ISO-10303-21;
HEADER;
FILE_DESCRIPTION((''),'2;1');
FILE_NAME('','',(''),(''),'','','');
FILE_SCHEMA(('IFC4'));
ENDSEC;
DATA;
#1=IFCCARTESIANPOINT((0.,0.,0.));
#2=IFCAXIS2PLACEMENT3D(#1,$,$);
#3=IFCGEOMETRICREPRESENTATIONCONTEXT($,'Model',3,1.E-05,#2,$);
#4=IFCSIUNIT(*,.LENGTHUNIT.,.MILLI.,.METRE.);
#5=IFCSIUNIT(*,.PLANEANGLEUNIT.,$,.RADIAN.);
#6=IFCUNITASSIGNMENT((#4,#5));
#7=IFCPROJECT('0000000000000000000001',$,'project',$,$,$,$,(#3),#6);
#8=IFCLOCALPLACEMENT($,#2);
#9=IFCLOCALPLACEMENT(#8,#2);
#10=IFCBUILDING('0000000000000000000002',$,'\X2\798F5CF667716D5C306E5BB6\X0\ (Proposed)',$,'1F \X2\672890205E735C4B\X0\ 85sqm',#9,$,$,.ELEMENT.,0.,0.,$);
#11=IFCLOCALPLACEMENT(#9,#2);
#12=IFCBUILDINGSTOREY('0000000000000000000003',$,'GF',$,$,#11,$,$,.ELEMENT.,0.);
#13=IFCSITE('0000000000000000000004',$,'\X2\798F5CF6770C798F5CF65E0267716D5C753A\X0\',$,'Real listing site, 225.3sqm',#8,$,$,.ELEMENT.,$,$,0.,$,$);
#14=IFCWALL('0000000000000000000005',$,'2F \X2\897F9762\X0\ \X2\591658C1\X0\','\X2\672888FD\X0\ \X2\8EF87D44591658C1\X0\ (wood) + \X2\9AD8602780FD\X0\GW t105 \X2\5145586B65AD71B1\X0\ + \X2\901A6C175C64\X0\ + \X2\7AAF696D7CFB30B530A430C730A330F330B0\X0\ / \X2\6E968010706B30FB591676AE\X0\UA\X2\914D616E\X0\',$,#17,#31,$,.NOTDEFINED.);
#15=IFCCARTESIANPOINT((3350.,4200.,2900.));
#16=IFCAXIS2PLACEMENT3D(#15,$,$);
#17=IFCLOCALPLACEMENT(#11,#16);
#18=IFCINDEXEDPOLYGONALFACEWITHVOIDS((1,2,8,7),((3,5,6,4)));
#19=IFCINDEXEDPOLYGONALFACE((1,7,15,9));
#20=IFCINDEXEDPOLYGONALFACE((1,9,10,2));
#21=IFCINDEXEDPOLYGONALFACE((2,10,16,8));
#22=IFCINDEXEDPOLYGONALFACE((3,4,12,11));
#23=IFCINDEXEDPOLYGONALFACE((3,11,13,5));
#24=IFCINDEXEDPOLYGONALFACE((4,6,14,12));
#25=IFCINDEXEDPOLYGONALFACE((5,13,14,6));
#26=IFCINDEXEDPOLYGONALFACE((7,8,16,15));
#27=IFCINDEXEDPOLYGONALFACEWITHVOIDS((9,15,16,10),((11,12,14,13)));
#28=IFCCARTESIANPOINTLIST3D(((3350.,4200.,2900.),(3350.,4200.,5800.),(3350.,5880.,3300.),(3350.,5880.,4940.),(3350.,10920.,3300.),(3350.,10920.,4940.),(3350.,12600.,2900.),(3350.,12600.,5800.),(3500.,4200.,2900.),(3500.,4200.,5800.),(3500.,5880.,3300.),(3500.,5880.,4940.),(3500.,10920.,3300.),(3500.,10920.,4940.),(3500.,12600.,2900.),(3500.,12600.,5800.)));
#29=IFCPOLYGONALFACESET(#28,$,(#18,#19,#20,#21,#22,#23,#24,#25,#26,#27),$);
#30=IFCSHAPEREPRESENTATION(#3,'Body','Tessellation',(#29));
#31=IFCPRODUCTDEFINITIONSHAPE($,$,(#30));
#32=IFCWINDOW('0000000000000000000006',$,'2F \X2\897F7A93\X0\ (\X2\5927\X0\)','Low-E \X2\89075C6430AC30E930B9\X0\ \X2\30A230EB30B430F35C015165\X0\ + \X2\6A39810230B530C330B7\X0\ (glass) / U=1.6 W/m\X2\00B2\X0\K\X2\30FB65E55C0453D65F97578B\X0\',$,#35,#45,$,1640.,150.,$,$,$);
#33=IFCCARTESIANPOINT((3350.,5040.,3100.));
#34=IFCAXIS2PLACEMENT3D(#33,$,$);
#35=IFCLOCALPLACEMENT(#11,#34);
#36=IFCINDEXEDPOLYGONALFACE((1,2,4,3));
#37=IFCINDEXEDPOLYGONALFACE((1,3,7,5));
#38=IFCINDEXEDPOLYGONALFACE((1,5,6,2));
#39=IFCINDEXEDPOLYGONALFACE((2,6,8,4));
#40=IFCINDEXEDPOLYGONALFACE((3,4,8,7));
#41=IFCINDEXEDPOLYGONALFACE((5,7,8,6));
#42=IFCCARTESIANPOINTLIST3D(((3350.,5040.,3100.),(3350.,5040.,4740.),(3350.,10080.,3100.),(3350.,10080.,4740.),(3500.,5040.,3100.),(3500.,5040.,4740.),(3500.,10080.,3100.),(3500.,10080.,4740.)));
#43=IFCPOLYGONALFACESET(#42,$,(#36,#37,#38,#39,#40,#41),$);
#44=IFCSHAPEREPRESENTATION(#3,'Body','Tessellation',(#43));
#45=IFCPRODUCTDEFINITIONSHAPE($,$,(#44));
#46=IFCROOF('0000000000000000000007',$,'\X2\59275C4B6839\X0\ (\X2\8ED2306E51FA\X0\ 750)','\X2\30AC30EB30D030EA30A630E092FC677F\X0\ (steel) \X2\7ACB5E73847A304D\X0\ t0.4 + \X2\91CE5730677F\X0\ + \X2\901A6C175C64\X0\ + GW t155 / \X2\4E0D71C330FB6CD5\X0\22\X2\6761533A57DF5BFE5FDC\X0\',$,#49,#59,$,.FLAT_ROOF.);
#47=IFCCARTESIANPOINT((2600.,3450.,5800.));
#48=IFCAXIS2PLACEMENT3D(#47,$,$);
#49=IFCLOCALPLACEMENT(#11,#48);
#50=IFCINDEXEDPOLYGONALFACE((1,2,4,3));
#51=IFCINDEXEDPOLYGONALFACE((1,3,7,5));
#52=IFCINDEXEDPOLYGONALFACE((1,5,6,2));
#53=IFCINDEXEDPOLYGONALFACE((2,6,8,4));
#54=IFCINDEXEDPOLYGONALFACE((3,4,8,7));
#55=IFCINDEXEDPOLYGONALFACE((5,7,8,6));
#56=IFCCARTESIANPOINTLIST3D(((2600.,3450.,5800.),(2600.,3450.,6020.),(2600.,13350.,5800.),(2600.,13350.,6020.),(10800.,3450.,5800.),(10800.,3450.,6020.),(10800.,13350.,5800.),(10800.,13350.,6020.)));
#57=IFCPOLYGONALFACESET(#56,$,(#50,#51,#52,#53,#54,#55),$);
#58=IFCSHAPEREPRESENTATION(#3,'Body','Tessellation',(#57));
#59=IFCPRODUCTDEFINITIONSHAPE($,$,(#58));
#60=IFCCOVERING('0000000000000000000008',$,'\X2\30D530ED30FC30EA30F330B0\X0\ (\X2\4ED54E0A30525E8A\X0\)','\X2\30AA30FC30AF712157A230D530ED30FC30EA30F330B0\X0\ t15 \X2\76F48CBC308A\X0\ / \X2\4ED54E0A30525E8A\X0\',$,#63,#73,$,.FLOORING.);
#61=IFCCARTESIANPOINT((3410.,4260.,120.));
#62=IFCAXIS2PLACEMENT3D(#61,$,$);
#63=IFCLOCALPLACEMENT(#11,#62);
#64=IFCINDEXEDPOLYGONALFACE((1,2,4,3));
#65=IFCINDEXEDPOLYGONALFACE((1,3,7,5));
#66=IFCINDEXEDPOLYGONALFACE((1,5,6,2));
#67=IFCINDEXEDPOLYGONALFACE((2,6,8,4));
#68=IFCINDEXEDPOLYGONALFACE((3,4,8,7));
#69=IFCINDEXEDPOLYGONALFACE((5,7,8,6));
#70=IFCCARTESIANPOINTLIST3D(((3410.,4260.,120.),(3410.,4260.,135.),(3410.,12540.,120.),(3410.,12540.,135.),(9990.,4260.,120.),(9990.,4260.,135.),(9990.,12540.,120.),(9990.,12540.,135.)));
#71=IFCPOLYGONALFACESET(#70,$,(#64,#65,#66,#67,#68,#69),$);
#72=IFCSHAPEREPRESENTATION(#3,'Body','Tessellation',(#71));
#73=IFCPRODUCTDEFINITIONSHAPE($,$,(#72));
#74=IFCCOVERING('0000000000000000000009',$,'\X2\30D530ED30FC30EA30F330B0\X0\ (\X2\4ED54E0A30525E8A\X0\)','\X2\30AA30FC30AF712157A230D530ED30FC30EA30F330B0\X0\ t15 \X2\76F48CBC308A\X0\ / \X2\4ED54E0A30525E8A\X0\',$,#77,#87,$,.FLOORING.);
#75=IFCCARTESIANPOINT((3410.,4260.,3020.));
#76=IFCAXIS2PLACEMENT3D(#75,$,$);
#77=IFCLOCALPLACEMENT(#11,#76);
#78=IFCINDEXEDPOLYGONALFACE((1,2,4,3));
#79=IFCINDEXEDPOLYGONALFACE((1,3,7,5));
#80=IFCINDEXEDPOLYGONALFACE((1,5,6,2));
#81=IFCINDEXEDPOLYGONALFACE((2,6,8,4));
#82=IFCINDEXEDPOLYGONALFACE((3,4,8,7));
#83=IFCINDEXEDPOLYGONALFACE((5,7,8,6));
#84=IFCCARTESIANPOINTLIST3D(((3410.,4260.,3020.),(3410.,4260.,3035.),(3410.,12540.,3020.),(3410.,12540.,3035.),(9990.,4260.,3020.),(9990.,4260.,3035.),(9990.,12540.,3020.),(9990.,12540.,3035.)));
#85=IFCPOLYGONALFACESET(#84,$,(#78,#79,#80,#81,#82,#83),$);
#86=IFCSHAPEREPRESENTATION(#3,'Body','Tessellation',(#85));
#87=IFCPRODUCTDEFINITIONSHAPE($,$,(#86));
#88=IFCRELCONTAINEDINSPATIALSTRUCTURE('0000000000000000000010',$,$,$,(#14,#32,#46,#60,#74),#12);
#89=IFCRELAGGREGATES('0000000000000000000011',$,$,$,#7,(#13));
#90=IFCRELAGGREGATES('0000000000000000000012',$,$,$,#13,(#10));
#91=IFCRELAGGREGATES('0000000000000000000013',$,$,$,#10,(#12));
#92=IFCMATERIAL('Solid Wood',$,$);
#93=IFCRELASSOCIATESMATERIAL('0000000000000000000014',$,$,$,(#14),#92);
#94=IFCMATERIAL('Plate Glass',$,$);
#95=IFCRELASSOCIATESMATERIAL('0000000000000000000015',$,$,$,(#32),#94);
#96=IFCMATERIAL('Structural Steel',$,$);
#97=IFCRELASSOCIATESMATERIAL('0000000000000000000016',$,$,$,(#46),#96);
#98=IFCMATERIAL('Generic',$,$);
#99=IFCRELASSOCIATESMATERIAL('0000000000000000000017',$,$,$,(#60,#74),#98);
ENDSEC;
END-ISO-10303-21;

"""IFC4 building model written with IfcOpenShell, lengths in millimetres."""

from ifc_helpers import new_model, si_unit, frame, frame_2d, origin, place, context, project, spatial, rectangle, extrude, material, element, fill, save


model = new_model("IFC4")

# Units and contexts
model_context = context("Model", 3, precision=1e-05, world=origin())
ifc_project = project(units=[si_unit("LENGTHUNIT", "METRE", prefix="MILLI"), si_unit("PLANEANGLEUNIT", "RADIAN")], contexts=[model_context])

# Site, building, storey
site_placement = place(None, origin())
site = spatial("IfcSite", under=ifc_project, at=site_placement, Name="福島県福島市東浜町", ObjectType="Real listing site, 225.3sqm", CompositionType="ELEMENT", RefElevation=0.0)
building_placement = place(site_placement, origin())
building = spatial("IfcBuilding", under=site, at=building_placement, Name="福島東浜の家 (Proposed)", ObjectType="1F 木造平屋 85sqm", CompositionType="ELEMENT", ElevationOfRefHeight=0.0, ElevationOfTerrain=0.0)
storey_placement = place(building_placement, origin())
storey = spatial("IfcBuildingStorey", under=building, at=storey_placement, Name="GF", CompositionType="ELEMENT", Elevation=0.0)

# Shared definitions
ifc_material_1 = material(Name="Solid Wood")
ifc_material_2 = material(Name="Generic")

# Shared definitions
ifc_material_3 = material(Name="Plate Glass")

# Wall, opening, window
wall_1_placement = place(storey_placement, frame((3350.0, 4200.0, 2900.0)))
wall_1 = element("IfcWall", 1, at=wall_1_placement, inside=storey, material=ifc_material_1, Name="2F 西面 外壁", Description="木製 軸組外壁 (wood) + 高性能GW t105 充填断熱 + 通気層 + 窯業系サイディング / 準耐火・外皮UA配慮", PredefinedType="NOTDEFINED", context=model_context, shape_type="SweptSolid", body=[
    extrude(rectangle(XDim=150.0, YDim=8400.0, at=frame_2d((75.0, 4200.0))), frame((3350.0, 4200.0, 2900.0)), (0.0, 0.0, 1.0), 2900.0),
])
opening_1_placement = place(storey_placement, frame((3350.0, 5040.0, 3100.0)))
opening_1 = element("IfcOpeningElement", 2, at=opening_1_placement, cuts=wall_1, PredefinedType="NOTDEFINED", context=model_context, shape_type="SweptSolid", body=[
    extrude(rectangle(XDim=150.0, YDim=5040.0, at=frame_2d((75.0, 2520.0))), frame((3350.0, 5040.0, 3100.0)), (0.0, 0.0, 1.0), 1640.0),
])
window_1_placement = place(storey_placement, frame((3350.0, 5040.0, 3100.0)))
window_1 = element("IfcWindow", 3, at=window_1_placement, inside=storey, material=ifc_material_3, Name="2F 西窓 (大)", Description="Low-E 複層ガラス アルゴン封入 + 樹脂サッシ (glass) / U=1.6 W/m²K・日射取得型", OverallHeight=1640.0, OverallWidth=150.0, context=model_context, shape_type="SweptSolid", body=[
    extrude(rectangle(XDim=150.0, YDim=5040.0, at=frame_2d((75.0, 2520.0))), frame((3350.0, 5040.0, 3100.0)), (0.0, 0.0, 1.0), 1640.0),
])
fill(opening_1, window_1)

# Roof
ifc_material_4 = material(Name="Structural Steel")
roof_placement = place(storey_placement, frame((2600.0, 3450.0, 5800.0)))
element("IfcRoof", 4, at=roof_placement, inside=storey, material=ifc_material_4, Name="大屋根 (軒の出 750)", Description="ガルバリウム鋼板 (steel) 立平葺き t0.4 + 野地板 + 通気層 + GW t155 / 不燃・法22条区域対応", PredefinedType="FLAT_ROOF", context=model_context, shape_type="SweptSolid", body=[
    extrude(rectangle(XDim=8200.0, YDim=9900.0, at=frame_2d((4100.0, 4950.0))), frame((2600.0, 3450.0, 5800.0)), (0.0, 0.0, 1.0), 220.0),
])

# Coverings
covering_1_placement = place(storey_placement, frame((3410.0, 4260.0, 120.0)))
element("IfcCovering", 5, at=covering_1_placement, inside=storey, material=ifc_material_2, Name="フローリング (仕上げ床)", Description="オーク無垢フローリング t15 直貼り / 仕上げ床", PredefinedType="FLOORING", context=model_context, shape_type="SweptSolid", body=[
    extrude(rectangle(XDim=6580.0, YDim=8280.0, at=frame_2d((3290.0, 4140.0))), frame((3410.0, 4260.0, 120.0)), (0.0, 0.0, 1.0), 15.0),
])
covering_2_placement = place(storey_placement, frame((3410.0, 4260.0, 3020.0)))
element("IfcCovering", 6, at=covering_2_placement, inside=storey, material=ifc_material_2, Name="フローリング (仕上げ床)", Description="オーク無垢フローリング t15 直貼り / 仕上げ床", PredefinedType="FLOORING", context=model_context, shape_type="SweptSolid", body=[
    extrude(rectangle(XDim=6580.0, YDim=8280.0, at=frame_2d((3290.0, 4140.0))), frame((3410.0, 4260.0, 3020.0)), (0.0, 0.0, 1.0), 15.0),
])

save(model, "model.ifc")
